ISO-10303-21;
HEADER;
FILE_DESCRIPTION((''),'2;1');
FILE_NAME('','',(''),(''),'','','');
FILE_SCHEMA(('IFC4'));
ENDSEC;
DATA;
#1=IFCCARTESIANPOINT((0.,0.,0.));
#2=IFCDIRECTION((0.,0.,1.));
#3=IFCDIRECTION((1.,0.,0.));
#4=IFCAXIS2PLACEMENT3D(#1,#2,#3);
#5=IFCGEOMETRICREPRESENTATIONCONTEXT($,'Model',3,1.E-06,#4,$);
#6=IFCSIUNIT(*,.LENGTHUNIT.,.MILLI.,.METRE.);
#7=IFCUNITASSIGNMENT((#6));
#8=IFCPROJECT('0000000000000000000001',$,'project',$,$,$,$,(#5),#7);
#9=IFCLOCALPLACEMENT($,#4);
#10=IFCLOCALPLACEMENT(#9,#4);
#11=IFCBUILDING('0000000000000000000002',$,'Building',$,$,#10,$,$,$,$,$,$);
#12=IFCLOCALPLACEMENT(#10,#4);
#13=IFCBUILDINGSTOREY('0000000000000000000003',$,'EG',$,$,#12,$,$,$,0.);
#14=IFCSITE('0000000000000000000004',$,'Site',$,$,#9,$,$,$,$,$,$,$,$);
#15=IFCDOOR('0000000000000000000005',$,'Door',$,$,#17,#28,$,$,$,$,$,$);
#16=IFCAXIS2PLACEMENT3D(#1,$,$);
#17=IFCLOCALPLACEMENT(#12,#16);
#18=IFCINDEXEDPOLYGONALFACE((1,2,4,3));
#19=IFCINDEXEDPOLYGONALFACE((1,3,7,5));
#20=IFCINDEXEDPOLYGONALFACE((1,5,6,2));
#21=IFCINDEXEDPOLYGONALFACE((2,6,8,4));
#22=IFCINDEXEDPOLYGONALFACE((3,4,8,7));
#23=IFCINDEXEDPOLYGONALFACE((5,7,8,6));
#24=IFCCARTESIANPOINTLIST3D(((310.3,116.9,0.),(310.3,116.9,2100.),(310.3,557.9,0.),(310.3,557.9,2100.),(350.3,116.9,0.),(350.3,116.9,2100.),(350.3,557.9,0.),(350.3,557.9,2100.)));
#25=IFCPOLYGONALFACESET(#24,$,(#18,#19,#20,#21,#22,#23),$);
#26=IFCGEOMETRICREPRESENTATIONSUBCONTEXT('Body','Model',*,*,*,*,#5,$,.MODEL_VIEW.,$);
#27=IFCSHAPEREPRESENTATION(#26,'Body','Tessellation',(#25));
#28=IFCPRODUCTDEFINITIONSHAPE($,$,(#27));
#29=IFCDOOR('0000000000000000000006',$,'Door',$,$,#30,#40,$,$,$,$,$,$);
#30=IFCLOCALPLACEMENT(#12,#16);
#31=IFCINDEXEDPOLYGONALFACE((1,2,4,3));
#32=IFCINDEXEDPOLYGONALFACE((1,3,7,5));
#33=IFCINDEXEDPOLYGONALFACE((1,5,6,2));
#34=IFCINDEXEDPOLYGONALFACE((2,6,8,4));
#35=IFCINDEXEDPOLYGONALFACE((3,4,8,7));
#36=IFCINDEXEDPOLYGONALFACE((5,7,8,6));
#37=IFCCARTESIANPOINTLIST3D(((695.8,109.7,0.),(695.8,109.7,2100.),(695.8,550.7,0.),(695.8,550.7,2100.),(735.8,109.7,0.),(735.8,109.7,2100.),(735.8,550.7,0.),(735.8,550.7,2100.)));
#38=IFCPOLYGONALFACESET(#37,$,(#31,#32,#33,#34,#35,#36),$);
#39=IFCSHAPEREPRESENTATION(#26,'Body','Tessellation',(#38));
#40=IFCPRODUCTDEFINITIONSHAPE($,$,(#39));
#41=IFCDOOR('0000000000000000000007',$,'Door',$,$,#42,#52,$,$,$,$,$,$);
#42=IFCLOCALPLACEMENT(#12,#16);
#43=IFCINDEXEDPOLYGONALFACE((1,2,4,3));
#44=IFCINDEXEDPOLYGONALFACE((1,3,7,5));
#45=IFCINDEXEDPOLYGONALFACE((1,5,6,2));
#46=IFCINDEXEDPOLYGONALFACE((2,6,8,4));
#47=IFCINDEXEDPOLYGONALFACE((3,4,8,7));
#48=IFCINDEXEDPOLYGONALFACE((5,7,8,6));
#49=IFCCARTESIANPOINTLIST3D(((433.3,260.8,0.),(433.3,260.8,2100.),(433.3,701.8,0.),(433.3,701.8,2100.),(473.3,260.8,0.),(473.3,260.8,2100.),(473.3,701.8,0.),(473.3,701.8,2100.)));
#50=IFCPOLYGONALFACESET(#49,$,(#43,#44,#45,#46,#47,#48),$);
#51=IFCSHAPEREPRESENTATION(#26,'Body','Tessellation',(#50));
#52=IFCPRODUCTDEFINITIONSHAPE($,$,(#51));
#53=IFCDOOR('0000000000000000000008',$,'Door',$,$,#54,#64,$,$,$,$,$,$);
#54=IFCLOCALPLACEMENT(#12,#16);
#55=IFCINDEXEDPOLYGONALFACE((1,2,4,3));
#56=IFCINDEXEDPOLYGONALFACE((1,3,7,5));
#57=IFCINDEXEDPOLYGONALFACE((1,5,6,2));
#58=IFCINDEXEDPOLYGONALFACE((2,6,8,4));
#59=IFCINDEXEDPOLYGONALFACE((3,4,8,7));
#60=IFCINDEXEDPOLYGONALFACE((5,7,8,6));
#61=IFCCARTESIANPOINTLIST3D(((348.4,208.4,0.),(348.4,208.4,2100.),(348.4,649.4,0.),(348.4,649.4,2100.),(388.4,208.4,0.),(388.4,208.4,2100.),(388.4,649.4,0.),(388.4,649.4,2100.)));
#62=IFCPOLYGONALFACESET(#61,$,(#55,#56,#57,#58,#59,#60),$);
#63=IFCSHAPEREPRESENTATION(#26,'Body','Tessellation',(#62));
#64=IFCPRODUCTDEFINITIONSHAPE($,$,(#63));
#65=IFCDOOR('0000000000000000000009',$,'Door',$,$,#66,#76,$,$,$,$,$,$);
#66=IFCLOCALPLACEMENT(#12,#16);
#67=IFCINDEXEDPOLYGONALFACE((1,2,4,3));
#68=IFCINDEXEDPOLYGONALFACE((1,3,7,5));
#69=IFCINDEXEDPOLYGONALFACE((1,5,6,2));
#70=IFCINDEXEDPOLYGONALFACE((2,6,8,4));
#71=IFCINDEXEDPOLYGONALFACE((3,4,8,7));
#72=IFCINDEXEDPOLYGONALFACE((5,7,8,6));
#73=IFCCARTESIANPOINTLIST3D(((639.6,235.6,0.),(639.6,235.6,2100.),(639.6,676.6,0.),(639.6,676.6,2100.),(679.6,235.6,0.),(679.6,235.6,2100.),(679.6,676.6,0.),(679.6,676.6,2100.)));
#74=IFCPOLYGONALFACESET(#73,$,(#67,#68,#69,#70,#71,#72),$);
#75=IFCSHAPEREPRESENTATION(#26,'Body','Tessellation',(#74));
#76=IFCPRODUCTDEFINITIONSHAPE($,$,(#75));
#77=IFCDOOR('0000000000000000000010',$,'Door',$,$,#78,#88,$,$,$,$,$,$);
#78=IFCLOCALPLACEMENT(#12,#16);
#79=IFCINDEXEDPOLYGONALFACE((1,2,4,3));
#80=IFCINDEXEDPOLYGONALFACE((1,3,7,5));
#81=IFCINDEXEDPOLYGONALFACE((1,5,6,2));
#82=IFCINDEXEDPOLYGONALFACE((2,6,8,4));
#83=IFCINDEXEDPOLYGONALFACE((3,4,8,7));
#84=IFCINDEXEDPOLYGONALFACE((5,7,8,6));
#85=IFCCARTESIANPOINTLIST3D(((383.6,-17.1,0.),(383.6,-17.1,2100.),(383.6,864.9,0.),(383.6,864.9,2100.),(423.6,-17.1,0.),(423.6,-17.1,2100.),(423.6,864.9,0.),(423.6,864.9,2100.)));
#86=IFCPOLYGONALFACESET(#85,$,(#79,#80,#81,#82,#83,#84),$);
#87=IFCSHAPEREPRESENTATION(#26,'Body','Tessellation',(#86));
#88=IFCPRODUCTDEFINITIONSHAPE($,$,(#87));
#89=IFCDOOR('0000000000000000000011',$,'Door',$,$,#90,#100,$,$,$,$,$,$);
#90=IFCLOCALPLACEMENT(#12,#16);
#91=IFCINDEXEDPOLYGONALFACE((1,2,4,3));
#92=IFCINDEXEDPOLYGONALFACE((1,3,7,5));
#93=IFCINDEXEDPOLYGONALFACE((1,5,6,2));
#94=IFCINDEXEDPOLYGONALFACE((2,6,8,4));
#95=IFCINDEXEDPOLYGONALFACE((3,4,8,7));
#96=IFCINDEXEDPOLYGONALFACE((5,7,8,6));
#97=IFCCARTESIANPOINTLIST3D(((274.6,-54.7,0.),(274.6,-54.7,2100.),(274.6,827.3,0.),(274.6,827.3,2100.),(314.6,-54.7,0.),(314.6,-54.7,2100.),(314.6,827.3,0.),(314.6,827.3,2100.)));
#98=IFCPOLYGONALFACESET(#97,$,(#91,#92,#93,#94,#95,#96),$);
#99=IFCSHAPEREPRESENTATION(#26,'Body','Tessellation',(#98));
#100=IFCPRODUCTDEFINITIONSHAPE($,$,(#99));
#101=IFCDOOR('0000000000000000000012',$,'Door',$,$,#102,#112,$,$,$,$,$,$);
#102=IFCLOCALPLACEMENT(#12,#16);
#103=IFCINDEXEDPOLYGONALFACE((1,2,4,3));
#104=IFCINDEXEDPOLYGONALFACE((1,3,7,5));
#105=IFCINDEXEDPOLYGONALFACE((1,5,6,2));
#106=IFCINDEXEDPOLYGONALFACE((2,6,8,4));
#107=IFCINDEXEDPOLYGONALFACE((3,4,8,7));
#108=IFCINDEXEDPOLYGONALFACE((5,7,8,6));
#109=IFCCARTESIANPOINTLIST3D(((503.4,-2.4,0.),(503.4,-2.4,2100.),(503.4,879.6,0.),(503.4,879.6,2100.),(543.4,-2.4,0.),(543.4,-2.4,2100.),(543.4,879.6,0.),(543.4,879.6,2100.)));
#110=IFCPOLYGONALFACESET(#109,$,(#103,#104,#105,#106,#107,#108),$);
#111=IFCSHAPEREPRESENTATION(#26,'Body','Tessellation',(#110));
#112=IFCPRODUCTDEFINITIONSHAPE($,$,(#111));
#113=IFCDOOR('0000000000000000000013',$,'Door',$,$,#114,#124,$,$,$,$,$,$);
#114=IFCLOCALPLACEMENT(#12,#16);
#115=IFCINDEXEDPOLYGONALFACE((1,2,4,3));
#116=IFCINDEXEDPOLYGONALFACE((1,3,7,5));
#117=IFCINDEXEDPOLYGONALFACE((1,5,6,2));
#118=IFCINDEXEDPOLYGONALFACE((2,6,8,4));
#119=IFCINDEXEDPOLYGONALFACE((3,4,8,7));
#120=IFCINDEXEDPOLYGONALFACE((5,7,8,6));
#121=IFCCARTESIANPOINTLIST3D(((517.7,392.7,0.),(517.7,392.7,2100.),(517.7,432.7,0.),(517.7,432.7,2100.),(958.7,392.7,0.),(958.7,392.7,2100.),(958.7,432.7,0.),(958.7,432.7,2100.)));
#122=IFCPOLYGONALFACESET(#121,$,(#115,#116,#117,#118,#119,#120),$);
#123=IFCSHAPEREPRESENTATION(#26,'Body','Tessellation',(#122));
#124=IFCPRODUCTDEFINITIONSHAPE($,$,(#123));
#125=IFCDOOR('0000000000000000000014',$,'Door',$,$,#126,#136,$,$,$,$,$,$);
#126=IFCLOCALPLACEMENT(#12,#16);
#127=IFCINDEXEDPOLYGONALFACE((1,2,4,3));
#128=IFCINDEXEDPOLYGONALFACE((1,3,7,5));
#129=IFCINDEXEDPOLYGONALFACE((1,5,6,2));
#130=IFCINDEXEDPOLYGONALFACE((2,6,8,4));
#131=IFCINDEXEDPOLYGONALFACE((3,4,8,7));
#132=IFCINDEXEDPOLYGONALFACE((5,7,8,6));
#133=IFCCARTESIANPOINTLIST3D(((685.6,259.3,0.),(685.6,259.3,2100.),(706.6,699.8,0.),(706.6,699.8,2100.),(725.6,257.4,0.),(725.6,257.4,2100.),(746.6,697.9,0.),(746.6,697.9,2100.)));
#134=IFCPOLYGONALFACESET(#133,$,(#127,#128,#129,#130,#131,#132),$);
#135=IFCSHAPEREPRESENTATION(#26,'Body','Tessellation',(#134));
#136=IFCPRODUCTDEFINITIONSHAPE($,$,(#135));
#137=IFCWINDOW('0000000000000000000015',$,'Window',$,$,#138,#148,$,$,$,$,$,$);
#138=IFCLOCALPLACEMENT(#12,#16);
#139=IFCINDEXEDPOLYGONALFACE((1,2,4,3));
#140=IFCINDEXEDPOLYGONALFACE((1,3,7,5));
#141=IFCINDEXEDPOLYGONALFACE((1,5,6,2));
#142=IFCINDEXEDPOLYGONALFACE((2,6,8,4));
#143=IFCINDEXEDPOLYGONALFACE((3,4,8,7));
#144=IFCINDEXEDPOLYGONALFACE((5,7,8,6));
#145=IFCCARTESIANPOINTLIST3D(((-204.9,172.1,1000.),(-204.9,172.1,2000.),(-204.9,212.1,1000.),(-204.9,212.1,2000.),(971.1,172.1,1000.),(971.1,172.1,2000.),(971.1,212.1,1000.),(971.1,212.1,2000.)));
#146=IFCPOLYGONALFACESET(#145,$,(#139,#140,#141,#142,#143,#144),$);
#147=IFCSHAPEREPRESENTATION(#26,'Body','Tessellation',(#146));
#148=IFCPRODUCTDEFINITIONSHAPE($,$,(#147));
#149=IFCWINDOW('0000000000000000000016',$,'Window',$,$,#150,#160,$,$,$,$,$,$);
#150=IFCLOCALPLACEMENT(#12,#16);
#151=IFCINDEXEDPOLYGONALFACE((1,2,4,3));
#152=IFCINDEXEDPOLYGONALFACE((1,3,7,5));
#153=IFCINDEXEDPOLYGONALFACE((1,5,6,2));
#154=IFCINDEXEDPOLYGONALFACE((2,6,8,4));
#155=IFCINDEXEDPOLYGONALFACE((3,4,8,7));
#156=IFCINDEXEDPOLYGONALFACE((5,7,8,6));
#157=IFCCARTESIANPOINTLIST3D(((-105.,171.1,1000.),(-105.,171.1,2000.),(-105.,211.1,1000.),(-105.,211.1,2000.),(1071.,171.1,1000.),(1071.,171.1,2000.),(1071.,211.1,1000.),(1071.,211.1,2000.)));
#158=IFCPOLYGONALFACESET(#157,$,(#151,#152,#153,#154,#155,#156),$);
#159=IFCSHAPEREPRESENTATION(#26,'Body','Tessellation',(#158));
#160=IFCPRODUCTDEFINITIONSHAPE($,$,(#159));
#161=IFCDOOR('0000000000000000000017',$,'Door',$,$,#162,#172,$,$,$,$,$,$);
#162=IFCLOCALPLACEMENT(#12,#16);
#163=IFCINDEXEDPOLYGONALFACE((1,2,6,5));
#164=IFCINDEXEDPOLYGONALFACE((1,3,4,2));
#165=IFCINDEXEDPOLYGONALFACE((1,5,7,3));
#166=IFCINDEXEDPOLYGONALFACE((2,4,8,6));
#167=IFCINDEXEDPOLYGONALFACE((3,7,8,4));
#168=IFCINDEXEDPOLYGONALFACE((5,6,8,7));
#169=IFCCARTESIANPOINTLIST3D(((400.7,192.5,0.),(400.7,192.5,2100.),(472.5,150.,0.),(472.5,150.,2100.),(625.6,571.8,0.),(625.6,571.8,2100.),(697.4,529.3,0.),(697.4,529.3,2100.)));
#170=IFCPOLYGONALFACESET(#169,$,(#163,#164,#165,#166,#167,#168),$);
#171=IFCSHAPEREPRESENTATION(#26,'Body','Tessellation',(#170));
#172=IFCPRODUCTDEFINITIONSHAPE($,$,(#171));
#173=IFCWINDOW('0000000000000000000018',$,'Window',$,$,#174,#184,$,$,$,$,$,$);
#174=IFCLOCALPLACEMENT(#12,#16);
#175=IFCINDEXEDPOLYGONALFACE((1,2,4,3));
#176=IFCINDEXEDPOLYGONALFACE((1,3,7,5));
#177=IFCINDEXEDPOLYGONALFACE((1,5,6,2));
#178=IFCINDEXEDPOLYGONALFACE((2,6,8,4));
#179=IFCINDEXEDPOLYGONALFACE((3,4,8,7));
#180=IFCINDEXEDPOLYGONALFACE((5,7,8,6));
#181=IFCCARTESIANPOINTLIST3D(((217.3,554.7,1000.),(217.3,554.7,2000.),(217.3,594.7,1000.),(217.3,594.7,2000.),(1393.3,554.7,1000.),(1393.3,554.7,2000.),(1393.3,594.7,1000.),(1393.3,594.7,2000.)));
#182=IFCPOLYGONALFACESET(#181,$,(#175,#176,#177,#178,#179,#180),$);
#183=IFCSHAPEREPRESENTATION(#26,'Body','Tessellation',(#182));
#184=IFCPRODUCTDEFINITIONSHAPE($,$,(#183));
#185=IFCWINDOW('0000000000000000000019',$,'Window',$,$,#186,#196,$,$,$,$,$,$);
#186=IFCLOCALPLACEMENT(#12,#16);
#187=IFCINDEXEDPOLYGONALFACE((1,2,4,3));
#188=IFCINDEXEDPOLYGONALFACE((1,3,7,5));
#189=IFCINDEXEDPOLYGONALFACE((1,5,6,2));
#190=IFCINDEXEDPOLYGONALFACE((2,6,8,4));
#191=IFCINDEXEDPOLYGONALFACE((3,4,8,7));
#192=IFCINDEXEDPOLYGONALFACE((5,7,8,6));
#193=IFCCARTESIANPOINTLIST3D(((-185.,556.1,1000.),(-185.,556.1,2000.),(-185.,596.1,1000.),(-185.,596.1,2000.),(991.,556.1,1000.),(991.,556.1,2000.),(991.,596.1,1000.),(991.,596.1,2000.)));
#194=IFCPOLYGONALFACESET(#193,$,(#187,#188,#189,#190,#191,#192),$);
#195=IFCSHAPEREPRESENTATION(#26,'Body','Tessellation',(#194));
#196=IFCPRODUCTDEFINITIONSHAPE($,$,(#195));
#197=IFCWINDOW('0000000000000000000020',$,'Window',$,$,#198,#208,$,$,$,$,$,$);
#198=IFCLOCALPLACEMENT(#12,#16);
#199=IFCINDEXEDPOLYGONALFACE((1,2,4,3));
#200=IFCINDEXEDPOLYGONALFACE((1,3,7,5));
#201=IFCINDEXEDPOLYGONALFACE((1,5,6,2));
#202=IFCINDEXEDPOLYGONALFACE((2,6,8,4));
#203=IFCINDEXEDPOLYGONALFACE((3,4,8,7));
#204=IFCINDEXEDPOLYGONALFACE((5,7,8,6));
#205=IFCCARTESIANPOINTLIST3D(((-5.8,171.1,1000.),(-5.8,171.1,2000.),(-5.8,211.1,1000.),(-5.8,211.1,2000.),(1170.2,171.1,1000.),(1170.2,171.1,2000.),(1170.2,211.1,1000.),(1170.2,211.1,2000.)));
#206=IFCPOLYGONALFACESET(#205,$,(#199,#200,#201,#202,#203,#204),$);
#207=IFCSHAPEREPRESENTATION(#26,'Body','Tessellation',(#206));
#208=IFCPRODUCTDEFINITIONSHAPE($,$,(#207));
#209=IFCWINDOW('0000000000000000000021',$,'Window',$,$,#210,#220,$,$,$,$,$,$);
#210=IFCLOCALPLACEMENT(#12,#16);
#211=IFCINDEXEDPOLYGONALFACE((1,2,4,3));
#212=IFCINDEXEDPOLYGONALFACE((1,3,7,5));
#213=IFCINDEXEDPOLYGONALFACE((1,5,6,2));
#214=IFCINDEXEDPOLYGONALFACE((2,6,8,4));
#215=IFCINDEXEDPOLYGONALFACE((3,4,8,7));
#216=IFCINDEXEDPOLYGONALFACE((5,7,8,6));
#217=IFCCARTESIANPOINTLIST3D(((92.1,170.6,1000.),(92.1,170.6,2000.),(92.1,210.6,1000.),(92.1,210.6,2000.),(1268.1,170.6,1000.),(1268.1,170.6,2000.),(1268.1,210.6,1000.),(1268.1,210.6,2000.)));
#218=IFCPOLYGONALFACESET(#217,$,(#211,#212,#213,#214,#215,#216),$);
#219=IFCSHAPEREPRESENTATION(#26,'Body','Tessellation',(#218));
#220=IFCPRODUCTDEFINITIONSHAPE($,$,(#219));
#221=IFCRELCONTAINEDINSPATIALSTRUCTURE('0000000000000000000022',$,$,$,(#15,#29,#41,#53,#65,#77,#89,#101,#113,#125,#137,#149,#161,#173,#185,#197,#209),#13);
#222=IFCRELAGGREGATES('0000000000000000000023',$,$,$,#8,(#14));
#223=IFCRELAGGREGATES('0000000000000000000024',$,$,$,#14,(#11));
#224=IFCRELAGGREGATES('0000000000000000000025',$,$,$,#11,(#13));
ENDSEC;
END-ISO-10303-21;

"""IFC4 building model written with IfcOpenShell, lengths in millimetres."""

from ifc_helpers import new_model, si_unit, frame, origin_with_axes, place, context, subcontext, project, spatial, rectangle, extrude, element, save


model = new_model("IFC4")

# Units and contexts
model_context = context("Model", 3, precision=1e-06, world=origin_with_axes())
body_context = subcontext(model_context, "Body", "Model", "MODEL_VIEW")
ifc_project = project(units=[si_unit("LENGTHUNIT", "METRE", prefix="MILLI")], contexts=[model_context])

# Site, building, storey
site_placement = place(None, origin_with_axes())
site = spatial("IfcSite", under=ifc_project, at=site_placement, Name="Site")
building_placement = place(site_placement, origin_with_axes())
building = spatial("IfcBuilding", under=site, at=building_placement, Name="Building")
storey_placement = place(building_placement, origin_with_axes())
storey = spatial("IfcBuildingStorey", under=building, at=storey_placement, Name="EG", Elevation=0.0)

# Doors
door_1_placement = place(storey_placement, origin_with_axes())
element("IfcDoor", 1, at=door_1_placement, inside=storey, Name="Door", context=body_context, shape_type="SweptSolid", body=[
    extrude(rectangle(XDim=441.0, YDim=40.0), frame((330.3, 337.4, 0.0), z_axis=(0.0, 0.0, 1.0), x_axis=(0.0, 1.0, 0.0)), (0.0, 0.0, 1.0), 2100.0),
])
door_2_placement = place(storey_placement, origin_with_axes())
element("IfcDoor", 2, at=door_2_placement, inside=storey, Name="Door", context=body_context, shape_type="SweptSolid", body=[
    extrude(rectangle(XDim=441.0, YDim=40.0), frame((715.8, 330.2, 0.0), z_axis=(0.0, 0.0, 1.0), x_axis=(0.0, -1.0, 0.0)), (0.0, 0.0, 1.0), 2100.0),
])
door_3_placement = place(storey_placement, origin_with_axes())
element("IfcDoor", 3, at=door_3_placement, inside=storey, Name="Door", context=body_context, shape_type="SweptSolid", body=[
    extrude(rectangle(XDim=441.0, YDim=40.0), frame((453.3, 481.3, 0.0), z_axis=(0.0, 0.0, 1.0), x_axis=(0.0, 1.0, 0.0)), (0.0, 0.0, 1.0), 2100.0),
])
door_4_placement = place(storey_placement, origin_with_axes())
element("IfcDoor", 4, at=door_4_placement, inside=storey, Name="Door", context=body_context, shape_type="SweptSolid", body=[
    extrude(rectangle(XDim=441.0, YDim=40.0), frame((368.4, 428.9, 0.0), z_axis=(0.0, 0.0, 1.0), x_axis=(0.0, 1.0, 0.0)), (0.0, 0.0, 1.0), 2100.0),
])
door_5_placement = place(storey_placement, origin_with_axes())
element("IfcDoor", 5, at=door_5_placement, inside=storey, Name="Door", context=body_context, shape_type="SweptSolid", body=[
    extrude(rectangle(XDim=441.0, YDim=40.0), frame((659.6, 456.1, 0.0), z_axis=(0.0, 0.0, 1.0), x_axis=(0.0, 1.0, 0.0)), (0.0, 0.0, 1.0), 2100.0),
])
door_6_placement = place(storey_placement, origin_with_axes())
element("IfcDoor", 6, at=door_6_placement, inside=storey, Name="Door", context=body_context, shape_type="SweptSolid", body=[
    extrude(rectangle(XDim=882.0, YDim=40.0), frame((403.6, 423.9, 0.0), z_axis=(0.0, 0.0, 1.0), x_axis=(0.0, 1.0, 0.0)), (0.0, 0.0, 1.0), 2100.0),
])
door_7_placement = place(storey_placement, origin_with_axes())
element("IfcDoor", 7, at=door_7_placement, inside=storey, Name="Door", context=body_context, shape_type="SweptSolid", body=[
    extrude(rectangle(XDim=882.0, YDim=40.0), frame((294.6, 386.3, 0.0), z_axis=(0.0, 0.0, 1.0), x_axis=(0.0, 1.0, 0.0)), (0.0, 0.0, 1.0), 2100.0),
])
door_8_placement = place(storey_placement, origin_with_axes())
element("IfcDoor", 8, at=door_8_placement, inside=storey, Name="Door", context=body_context, shape_type="SweptSolid", body=[
    extrude(rectangle(XDim=882.0, YDim=40.0), frame((523.4, 438.6, 0.0), z_axis=(0.0, 0.0, 1.0), x_axis=(0.0, 1.0, 0.0)), (0.0, 0.0, 1.0), 2100.0),
])
door_9_placement = place(storey_placement, origin_with_axes())
element("IfcDoor", 9, at=door_9_placement, inside=storey, Name="Door", context=body_context, shape_type="SweptSolid", body=[
    extrude(rectangle(XDim=441.0, YDim=40.0), frame((738.2, 412.7, 0.0), z_axis=(0.0, 0.0, 1.0), x_axis=(-1.0, 0.0, 0.0)), (0.0, 0.0, 1.0), 2100.0),
])
door_10_placement = place(storey_placement, origin_with_axes())
element("IfcDoor", 10, at=door_10_placement, inside=storey, Name="Door", context=body_context, shape_type="SweptSolid", body=[
    extrude(rectangle(XDim=441.0, YDim=40.0), frame((716.1, 478.6, 0.0), z_axis=(0.0, 0.0, 1.0), x_axis=(-0.047565, -0.998868, 0.0)), (0.0, 0.0, 1.0), 2100.0),
])

# Windows
window_1_placement = place(storey_placement, origin_with_axes())
element("IfcWindow", 11, at=window_1_placement, inside=storey, Name="Window", context=body_context, shape_type="SweptSolid", body=[
    extrude(rectangle(XDim=1176.0, YDim=40.0), frame((383.1, 192.1, 1000.0), z_axis=(0.0, 0.0, 1.0), x_axis=(-1.0, 0.0, 0.0)), (0.0, 0.0, 1.0), 1000.0),
])
window_2_placement = place(storey_placement, origin_with_axes())
element("IfcWindow", 12, at=window_2_placement, inside=storey, Name="Window", context=body_context, shape_type="SweptSolid", body=[
    extrude(rectangle(XDim=1176.0, YDim=40.0), frame((483.0, 191.1, 1000.0), z_axis=(0.0, 0.0, 1.0), x_axis=(-1.0, 0.0, 0.0)), (0.0, 0.0, 1.0), 1000.0),
])

# Door
door_11_placement = place(storey_placement, origin_with_axes())
element("IfcDoor", 13, at=door_11_placement, inside=storey, Name="Door", context=body_context, shape_type="SweptSolid", body=[
    extrude(rectangle(XDim=441.0, YDim=83.5), frame((549.1, 360.9, 0.0), z_axis=(0.0, 0.0, 1.0), x_axis=(-0.510011, -0.860168, 0.0)), (0.0, 0.0, 1.0), 2100.0),
])

# Windows
window_3_placement = place(storey_placement, origin_with_axes())
element("IfcWindow", 14, at=window_3_placement, inside=storey, Name="Window", context=body_context, shape_type="SweptSolid", body=[
    extrude(rectangle(XDim=1176.0, YDim=40.0), frame((805.3, 574.7, 1000.0), z_axis=(0.0, 0.0, 1.0), x_axis=(-1.0, 0.0, 0.0)), (0.0, 0.0, 1.0), 1000.0),
])
window_4_placement = place(storey_placement, origin_with_axes())
element("IfcWindow", 15, at=window_4_placement, inside=storey, Name="Window", context=body_context, shape_type="SweptSolid", body=[
    extrude(rectangle(XDim=1176.0, YDim=40.0), frame((403.0, 576.1, 1000.0), z_axis=(0.0, 0.0, 1.0), x_axis=(-1.0, 0.0, 0.0)), (0.0, 0.0, 1.0), 1000.0),
])
window_5_placement = place(storey_placement, origin_with_axes())
element("IfcWindow", 16, at=window_5_placement, inside=storey, Name="Window", context=body_context, shape_type="SweptSolid", body=[
    extrude(rectangle(XDim=1176.0, YDim=40.0), frame((582.2, 191.1, 1000.0), z_axis=(0.0, 0.0, 1.0), x_axis=(-1.0, 0.0, 0.0)), (0.0, 0.0, 1.0), 1000.0),
])
window_6_placement = place(storey_placement, origin_with_axes())
element("IfcWindow", 17, at=window_6_placement, inside=storey, Name="Window", context=body_context, shape_type="SweptSolid", body=[
    extrude(rectangle(XDim=1176.0, YDim=40.0), frame((680.1, 190.6, 1000.0), z_axis=(0.0, 0.0, 1.0), x_axis=(-1.0, 0.0, 0.0)), (0.0, 0.0, 1.0), 1000.0),
])

save(model, "model.ifc")
